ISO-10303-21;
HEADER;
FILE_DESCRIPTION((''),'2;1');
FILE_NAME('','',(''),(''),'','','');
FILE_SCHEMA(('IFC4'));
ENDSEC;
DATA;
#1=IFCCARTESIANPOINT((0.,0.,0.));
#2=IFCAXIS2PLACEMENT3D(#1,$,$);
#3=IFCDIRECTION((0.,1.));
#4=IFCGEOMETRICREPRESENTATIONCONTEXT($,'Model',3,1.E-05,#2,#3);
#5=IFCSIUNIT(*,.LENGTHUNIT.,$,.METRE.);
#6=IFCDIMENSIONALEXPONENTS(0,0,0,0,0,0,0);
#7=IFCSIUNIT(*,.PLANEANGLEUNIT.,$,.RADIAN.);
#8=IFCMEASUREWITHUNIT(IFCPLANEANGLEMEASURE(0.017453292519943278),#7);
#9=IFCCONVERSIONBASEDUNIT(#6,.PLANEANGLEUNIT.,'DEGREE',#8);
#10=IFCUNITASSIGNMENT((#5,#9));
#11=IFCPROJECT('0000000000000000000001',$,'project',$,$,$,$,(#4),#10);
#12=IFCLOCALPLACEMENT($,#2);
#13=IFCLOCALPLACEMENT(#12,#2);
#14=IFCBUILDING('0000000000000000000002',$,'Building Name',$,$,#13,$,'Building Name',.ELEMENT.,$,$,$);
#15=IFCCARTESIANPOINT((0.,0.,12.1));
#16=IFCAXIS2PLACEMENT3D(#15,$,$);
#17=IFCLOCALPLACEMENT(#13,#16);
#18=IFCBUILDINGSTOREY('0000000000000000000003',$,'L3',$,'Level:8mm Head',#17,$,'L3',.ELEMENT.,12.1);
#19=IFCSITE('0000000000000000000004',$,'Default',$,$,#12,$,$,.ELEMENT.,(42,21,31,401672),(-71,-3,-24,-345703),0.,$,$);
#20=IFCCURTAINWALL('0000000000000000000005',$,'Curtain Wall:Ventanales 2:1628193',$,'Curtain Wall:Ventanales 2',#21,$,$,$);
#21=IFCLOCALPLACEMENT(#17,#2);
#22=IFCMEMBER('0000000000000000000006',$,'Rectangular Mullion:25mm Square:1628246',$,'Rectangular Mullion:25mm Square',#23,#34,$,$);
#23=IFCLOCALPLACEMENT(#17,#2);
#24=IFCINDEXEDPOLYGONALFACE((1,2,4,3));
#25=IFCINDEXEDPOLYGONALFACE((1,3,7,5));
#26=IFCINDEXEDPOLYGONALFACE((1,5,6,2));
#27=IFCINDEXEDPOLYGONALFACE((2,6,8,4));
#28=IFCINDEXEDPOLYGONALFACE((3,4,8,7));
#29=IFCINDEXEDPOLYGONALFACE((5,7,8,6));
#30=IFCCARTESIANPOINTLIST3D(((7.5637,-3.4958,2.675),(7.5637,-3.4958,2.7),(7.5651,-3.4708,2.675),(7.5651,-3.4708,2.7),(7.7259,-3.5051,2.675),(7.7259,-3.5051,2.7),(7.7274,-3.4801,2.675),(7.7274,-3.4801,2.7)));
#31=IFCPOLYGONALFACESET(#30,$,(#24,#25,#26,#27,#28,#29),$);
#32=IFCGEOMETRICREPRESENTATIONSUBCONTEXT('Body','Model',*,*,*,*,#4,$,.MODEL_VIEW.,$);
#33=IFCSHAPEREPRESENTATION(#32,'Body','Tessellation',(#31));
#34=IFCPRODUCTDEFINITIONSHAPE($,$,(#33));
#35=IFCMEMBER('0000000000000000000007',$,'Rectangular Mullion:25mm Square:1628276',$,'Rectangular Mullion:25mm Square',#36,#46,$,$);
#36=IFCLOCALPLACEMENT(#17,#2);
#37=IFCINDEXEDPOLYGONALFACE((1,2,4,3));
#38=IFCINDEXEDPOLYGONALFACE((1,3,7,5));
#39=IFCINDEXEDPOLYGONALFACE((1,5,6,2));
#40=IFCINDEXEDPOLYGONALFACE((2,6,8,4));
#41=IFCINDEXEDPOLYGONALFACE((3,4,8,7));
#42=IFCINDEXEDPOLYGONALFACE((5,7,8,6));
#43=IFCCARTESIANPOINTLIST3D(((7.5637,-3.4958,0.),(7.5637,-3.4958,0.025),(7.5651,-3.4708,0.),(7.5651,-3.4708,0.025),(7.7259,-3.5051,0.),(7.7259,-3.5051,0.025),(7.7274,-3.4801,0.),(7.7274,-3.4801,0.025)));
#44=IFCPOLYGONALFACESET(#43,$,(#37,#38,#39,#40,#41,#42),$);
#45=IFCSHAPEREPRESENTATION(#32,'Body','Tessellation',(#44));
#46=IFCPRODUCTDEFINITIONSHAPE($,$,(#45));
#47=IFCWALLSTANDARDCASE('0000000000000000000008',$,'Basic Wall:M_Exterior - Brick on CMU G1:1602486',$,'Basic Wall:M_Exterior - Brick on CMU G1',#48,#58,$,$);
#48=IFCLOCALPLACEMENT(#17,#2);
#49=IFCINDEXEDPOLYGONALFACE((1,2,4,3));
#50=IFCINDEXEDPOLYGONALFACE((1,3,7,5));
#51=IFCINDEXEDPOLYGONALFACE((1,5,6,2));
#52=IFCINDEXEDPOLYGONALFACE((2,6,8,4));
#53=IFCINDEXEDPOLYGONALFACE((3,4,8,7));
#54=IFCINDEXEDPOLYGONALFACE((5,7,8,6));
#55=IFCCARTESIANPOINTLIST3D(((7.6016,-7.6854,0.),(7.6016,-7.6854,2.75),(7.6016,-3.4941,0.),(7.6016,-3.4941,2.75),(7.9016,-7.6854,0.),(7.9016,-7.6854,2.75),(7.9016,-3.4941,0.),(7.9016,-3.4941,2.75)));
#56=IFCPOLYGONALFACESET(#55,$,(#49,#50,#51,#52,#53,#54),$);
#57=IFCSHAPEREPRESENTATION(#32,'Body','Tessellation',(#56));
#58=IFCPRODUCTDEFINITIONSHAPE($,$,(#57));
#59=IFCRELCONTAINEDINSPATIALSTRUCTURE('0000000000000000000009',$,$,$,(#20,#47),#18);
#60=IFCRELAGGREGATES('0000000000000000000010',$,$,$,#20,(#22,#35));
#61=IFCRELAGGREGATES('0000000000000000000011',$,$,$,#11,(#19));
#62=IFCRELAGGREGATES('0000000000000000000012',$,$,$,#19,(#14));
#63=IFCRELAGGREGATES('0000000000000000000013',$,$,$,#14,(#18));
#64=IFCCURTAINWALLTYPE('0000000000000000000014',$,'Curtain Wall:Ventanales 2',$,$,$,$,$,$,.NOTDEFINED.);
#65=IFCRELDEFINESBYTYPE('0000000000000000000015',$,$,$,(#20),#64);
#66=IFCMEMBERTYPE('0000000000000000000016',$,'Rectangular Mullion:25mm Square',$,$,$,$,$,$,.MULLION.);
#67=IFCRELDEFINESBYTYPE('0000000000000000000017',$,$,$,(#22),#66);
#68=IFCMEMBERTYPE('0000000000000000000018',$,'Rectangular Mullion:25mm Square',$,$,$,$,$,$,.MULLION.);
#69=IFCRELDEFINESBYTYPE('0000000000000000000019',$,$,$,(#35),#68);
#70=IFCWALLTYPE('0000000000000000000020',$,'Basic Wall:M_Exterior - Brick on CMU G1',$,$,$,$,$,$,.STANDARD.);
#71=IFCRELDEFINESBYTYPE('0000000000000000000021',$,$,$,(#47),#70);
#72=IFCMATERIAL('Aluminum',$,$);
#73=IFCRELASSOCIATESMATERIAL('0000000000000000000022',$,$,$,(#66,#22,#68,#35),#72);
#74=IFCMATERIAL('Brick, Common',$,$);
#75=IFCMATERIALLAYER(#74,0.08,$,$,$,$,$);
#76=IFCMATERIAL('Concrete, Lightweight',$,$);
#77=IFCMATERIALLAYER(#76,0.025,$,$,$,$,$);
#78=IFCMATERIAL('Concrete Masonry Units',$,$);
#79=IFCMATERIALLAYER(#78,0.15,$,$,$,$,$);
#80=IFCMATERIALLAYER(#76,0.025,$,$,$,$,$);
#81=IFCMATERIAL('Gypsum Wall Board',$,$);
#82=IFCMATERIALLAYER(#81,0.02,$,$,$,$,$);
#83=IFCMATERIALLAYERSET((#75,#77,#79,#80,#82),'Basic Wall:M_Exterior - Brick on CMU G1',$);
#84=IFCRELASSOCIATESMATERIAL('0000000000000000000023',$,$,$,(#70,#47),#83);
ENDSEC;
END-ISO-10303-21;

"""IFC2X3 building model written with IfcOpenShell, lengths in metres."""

from ifc_helpers import new_model, entity, si_unit, converted_unit, direction, frame, frame_2d, origin, origin_2d_with_axis, place, context, subcontext, project, spatial, rectangle, extrude, source, transform, mapped, material, layer, layer_set, layer_usage, type_object, type_shapes, element, aggregate, save


model = new_model("IFC2X3")

# Units and contexts
model_context = context("Model", 3, precision=1e-05, world=origin(), true_north=direction((0.0, 1.0)))
body_context = subcontext(model_context, "Body", "Model", "MODEL_VIEW")
ifc_project = project(units=[si_unit("LENGTHUNIT", "METRE"), converted_unit("PLANEANGLEUNIT", "DEGREE", entity("IfcPlaneAngleMeasure", 0.017453292519943278), si_unit("PLANEANGLEUNIT", "RADIAN"), dimensions=[0, 0, 0, 0, 0, 0, 0])], contexts=[model_context])

# Site, building, storey
site_placement = place(None, origin())
site = spatial("IfcSite", under=ifc_project, at=site_placement, Name="Default", CompositionType="ELEMENT", RefLatitude=(42, 21, 31, 401672), RefLongitude=(-71, -3, -24, -345703), RefElevation=0.0)
building_placement = place(site_placement, origin())
building = spatial("IfcBuilding", under=site, at=building_placement, Name="Building Name", LongName="Building Name", CompositionType="ELEMENT")
storey_placement = place(building_placement, frame((0.0, 0.0, 12.1)))
storey = spatial("IfcBuildingStorey", under=building, at=storey_placement, Name="L3", ObjectType="Level:8mm Head", LongName="L3", CompositionType="ELEMENT", Elevation=12.1)

# Curtain wall, members
curtain_wall_type = type_object("IfcCurtainWallType", Name="Curtain Wall:Ventanales 2", PredefinedType="NOTDEFINED")
curtain_wall_placement = place(storey_placement, frame((0.0, 0.0, -12.1)))
curtain_wall = element("IfcCurtainWall", 1, at=curtain_wall_placement, inside=storey, type_object=curtain_wall_type, Name="Curtain Wall:Ventanales 2:1628193", ObjectType="Curtain Wall:Ventanales 2")
ifc_material_1 = material(Name="Aluminum")
member_type_1 = type_object("IfcMemberType", Name="Rectangular Mullion:25mm Square", PredefinedType="MULLION", material=ifc_material_1)
shared_shape_1 = source(origin(), body_context, "Body", "SweptSolid", [
    extrude(rectangle(XDim=0.025, YDim=0.025, at=origin_2d_with_axis()), frame((-0.0125, 0.0, -0.1625), z_axis=(0.0, 0.0, 1.0), x_axis=(-1.0, 0.0, 0.0)), (0.0, 0.0, 1.0), 0.1625),
])
type_shapes(member_type_1, [shared_shape_1])
member_1_placement = place(curtain_wall_placement, frame((7.7266, -3.4926, 14.8), z_axis=(0.998353, -0.057365, 0.0), x_axis=(0.0, 0.0, 1.0)))
member_1 = element("IfcMember", 2, at=member_1_placement, type_object=member_type_1, material=ifc_material_1, Name="Rectangular Mullion:25mm Square:1628246", ObjectType="Rectangular Mullion:25mm Square", context=body_context, shape_type="MappedRepresentation", body=[
    mapped(shared_shape_1, transform((0.0, 0.0, 0.0), scale=1.0)),
])
member_type_2 = type_object("IfcMemberType", Name="Rectangular Mullion:25mm Square", PredefinedType="MULLION", material=ifc_material_1)
shared_shape_2 = source(origin(), body_context, "Body", "SweptSolid", [
    extrude(rectangle(XDim=0.025, YDim=0.025, at=origin_2d_with_axis()), frame((-0.0125, 0.0, -0.1625), z_axis=(0.0, 0.0, 1.0), x_axis=(-1.0, 0.0, 0.0)), (0.0, 0.0, 1.0), 0.1625),
])
type_shapes(member_type_2, [shared_shape_2])
member_2_placement = place(curtain_wall_placement, frame((7.5644, -3.4833, 12.1), z_axis=(-0.998353, 0.057365, 0.0), x_axis=(0.0, 0.0, -1.0)))
member_2 = element("IfcMember", 3, at=member_2_placement, type_object=member_type_2, material=ifc_material_1, Name="Rectangular Mullion:25mm Square:1628276", ObjectType="Rectangular Mullion:25mm Square", context=body_context, shape_type="MappedRepresentation", body=[
    mapped(shared_shape_2, transform((0.0, 0.0, 0.0), scale=1.0)),
])
aggregate(curtain_wall, [member_1, member_2])

# Wall
ifc_material_2 = material(Name="Brick, Common")
ifc_layer_1 = layer(ifc_material_2, 0.08)
ifc_material_3 = material(Name="Concrete, Lightweight")
ifc_layer_2 = layer(ifc_material_3, 0.025)
ifc_material_4 = material(Name="Concrete Masonry Units")
ifc_layer_3 = layer(ifc_material_4, 0.15)
ifc_layer_4 = layer(ifc_material_3, 0.025)
ifc_material_5 = material(Name="Gypsum Wall Board")
ifc_layer_5 = layer(ifc_material_5, 0.02)
ifc_layer_set = layer_set([ifc_layer_1, ifc_layer_2, ifc_layer_3, ifc_layer_4, ifc_layer_5], Name="Basic Wall:M_Exterior - Brick on CMU G1")
ifc_layer_usage = layer_usage(ifc_layer_set, "AXIS2", "NEGATIVE", 0.15)
wall_type = type_object("IfcWallType", Name="Basic Wall:M_Exterior - Brick on CMU G1", PredefinedType="STANDARD", material=ifc_layer_set)
wall_placement = place(storey_placement, frame((7.7516, -3.4941, 0.0), z_axis=(0.0, 0.0, 1.0), x_axis=(0.0, -1.0, 0.0)))
element("IfcWallStandardCase", 4, at=wall_placement, inside=storey, type_object=wall_type, material=ifc_layer_usage, Name="Basic Wall:M_Exterior - Brick on CMU G1:1602486", ObjectType="Basic Wall:M_Exterior - Brick on CMU G1", context=body_context, shape_type="SweptSolid", body=[
    extrude(rectangle(XDim=4.1914, YDim=0.3, at=frame_2d((2.0957, 0.0), x_axis=(-1.0, 0.0))), origin(), (0.0, 0.0, 1.0), 2.75),
])

save(model, "model.ifc")
